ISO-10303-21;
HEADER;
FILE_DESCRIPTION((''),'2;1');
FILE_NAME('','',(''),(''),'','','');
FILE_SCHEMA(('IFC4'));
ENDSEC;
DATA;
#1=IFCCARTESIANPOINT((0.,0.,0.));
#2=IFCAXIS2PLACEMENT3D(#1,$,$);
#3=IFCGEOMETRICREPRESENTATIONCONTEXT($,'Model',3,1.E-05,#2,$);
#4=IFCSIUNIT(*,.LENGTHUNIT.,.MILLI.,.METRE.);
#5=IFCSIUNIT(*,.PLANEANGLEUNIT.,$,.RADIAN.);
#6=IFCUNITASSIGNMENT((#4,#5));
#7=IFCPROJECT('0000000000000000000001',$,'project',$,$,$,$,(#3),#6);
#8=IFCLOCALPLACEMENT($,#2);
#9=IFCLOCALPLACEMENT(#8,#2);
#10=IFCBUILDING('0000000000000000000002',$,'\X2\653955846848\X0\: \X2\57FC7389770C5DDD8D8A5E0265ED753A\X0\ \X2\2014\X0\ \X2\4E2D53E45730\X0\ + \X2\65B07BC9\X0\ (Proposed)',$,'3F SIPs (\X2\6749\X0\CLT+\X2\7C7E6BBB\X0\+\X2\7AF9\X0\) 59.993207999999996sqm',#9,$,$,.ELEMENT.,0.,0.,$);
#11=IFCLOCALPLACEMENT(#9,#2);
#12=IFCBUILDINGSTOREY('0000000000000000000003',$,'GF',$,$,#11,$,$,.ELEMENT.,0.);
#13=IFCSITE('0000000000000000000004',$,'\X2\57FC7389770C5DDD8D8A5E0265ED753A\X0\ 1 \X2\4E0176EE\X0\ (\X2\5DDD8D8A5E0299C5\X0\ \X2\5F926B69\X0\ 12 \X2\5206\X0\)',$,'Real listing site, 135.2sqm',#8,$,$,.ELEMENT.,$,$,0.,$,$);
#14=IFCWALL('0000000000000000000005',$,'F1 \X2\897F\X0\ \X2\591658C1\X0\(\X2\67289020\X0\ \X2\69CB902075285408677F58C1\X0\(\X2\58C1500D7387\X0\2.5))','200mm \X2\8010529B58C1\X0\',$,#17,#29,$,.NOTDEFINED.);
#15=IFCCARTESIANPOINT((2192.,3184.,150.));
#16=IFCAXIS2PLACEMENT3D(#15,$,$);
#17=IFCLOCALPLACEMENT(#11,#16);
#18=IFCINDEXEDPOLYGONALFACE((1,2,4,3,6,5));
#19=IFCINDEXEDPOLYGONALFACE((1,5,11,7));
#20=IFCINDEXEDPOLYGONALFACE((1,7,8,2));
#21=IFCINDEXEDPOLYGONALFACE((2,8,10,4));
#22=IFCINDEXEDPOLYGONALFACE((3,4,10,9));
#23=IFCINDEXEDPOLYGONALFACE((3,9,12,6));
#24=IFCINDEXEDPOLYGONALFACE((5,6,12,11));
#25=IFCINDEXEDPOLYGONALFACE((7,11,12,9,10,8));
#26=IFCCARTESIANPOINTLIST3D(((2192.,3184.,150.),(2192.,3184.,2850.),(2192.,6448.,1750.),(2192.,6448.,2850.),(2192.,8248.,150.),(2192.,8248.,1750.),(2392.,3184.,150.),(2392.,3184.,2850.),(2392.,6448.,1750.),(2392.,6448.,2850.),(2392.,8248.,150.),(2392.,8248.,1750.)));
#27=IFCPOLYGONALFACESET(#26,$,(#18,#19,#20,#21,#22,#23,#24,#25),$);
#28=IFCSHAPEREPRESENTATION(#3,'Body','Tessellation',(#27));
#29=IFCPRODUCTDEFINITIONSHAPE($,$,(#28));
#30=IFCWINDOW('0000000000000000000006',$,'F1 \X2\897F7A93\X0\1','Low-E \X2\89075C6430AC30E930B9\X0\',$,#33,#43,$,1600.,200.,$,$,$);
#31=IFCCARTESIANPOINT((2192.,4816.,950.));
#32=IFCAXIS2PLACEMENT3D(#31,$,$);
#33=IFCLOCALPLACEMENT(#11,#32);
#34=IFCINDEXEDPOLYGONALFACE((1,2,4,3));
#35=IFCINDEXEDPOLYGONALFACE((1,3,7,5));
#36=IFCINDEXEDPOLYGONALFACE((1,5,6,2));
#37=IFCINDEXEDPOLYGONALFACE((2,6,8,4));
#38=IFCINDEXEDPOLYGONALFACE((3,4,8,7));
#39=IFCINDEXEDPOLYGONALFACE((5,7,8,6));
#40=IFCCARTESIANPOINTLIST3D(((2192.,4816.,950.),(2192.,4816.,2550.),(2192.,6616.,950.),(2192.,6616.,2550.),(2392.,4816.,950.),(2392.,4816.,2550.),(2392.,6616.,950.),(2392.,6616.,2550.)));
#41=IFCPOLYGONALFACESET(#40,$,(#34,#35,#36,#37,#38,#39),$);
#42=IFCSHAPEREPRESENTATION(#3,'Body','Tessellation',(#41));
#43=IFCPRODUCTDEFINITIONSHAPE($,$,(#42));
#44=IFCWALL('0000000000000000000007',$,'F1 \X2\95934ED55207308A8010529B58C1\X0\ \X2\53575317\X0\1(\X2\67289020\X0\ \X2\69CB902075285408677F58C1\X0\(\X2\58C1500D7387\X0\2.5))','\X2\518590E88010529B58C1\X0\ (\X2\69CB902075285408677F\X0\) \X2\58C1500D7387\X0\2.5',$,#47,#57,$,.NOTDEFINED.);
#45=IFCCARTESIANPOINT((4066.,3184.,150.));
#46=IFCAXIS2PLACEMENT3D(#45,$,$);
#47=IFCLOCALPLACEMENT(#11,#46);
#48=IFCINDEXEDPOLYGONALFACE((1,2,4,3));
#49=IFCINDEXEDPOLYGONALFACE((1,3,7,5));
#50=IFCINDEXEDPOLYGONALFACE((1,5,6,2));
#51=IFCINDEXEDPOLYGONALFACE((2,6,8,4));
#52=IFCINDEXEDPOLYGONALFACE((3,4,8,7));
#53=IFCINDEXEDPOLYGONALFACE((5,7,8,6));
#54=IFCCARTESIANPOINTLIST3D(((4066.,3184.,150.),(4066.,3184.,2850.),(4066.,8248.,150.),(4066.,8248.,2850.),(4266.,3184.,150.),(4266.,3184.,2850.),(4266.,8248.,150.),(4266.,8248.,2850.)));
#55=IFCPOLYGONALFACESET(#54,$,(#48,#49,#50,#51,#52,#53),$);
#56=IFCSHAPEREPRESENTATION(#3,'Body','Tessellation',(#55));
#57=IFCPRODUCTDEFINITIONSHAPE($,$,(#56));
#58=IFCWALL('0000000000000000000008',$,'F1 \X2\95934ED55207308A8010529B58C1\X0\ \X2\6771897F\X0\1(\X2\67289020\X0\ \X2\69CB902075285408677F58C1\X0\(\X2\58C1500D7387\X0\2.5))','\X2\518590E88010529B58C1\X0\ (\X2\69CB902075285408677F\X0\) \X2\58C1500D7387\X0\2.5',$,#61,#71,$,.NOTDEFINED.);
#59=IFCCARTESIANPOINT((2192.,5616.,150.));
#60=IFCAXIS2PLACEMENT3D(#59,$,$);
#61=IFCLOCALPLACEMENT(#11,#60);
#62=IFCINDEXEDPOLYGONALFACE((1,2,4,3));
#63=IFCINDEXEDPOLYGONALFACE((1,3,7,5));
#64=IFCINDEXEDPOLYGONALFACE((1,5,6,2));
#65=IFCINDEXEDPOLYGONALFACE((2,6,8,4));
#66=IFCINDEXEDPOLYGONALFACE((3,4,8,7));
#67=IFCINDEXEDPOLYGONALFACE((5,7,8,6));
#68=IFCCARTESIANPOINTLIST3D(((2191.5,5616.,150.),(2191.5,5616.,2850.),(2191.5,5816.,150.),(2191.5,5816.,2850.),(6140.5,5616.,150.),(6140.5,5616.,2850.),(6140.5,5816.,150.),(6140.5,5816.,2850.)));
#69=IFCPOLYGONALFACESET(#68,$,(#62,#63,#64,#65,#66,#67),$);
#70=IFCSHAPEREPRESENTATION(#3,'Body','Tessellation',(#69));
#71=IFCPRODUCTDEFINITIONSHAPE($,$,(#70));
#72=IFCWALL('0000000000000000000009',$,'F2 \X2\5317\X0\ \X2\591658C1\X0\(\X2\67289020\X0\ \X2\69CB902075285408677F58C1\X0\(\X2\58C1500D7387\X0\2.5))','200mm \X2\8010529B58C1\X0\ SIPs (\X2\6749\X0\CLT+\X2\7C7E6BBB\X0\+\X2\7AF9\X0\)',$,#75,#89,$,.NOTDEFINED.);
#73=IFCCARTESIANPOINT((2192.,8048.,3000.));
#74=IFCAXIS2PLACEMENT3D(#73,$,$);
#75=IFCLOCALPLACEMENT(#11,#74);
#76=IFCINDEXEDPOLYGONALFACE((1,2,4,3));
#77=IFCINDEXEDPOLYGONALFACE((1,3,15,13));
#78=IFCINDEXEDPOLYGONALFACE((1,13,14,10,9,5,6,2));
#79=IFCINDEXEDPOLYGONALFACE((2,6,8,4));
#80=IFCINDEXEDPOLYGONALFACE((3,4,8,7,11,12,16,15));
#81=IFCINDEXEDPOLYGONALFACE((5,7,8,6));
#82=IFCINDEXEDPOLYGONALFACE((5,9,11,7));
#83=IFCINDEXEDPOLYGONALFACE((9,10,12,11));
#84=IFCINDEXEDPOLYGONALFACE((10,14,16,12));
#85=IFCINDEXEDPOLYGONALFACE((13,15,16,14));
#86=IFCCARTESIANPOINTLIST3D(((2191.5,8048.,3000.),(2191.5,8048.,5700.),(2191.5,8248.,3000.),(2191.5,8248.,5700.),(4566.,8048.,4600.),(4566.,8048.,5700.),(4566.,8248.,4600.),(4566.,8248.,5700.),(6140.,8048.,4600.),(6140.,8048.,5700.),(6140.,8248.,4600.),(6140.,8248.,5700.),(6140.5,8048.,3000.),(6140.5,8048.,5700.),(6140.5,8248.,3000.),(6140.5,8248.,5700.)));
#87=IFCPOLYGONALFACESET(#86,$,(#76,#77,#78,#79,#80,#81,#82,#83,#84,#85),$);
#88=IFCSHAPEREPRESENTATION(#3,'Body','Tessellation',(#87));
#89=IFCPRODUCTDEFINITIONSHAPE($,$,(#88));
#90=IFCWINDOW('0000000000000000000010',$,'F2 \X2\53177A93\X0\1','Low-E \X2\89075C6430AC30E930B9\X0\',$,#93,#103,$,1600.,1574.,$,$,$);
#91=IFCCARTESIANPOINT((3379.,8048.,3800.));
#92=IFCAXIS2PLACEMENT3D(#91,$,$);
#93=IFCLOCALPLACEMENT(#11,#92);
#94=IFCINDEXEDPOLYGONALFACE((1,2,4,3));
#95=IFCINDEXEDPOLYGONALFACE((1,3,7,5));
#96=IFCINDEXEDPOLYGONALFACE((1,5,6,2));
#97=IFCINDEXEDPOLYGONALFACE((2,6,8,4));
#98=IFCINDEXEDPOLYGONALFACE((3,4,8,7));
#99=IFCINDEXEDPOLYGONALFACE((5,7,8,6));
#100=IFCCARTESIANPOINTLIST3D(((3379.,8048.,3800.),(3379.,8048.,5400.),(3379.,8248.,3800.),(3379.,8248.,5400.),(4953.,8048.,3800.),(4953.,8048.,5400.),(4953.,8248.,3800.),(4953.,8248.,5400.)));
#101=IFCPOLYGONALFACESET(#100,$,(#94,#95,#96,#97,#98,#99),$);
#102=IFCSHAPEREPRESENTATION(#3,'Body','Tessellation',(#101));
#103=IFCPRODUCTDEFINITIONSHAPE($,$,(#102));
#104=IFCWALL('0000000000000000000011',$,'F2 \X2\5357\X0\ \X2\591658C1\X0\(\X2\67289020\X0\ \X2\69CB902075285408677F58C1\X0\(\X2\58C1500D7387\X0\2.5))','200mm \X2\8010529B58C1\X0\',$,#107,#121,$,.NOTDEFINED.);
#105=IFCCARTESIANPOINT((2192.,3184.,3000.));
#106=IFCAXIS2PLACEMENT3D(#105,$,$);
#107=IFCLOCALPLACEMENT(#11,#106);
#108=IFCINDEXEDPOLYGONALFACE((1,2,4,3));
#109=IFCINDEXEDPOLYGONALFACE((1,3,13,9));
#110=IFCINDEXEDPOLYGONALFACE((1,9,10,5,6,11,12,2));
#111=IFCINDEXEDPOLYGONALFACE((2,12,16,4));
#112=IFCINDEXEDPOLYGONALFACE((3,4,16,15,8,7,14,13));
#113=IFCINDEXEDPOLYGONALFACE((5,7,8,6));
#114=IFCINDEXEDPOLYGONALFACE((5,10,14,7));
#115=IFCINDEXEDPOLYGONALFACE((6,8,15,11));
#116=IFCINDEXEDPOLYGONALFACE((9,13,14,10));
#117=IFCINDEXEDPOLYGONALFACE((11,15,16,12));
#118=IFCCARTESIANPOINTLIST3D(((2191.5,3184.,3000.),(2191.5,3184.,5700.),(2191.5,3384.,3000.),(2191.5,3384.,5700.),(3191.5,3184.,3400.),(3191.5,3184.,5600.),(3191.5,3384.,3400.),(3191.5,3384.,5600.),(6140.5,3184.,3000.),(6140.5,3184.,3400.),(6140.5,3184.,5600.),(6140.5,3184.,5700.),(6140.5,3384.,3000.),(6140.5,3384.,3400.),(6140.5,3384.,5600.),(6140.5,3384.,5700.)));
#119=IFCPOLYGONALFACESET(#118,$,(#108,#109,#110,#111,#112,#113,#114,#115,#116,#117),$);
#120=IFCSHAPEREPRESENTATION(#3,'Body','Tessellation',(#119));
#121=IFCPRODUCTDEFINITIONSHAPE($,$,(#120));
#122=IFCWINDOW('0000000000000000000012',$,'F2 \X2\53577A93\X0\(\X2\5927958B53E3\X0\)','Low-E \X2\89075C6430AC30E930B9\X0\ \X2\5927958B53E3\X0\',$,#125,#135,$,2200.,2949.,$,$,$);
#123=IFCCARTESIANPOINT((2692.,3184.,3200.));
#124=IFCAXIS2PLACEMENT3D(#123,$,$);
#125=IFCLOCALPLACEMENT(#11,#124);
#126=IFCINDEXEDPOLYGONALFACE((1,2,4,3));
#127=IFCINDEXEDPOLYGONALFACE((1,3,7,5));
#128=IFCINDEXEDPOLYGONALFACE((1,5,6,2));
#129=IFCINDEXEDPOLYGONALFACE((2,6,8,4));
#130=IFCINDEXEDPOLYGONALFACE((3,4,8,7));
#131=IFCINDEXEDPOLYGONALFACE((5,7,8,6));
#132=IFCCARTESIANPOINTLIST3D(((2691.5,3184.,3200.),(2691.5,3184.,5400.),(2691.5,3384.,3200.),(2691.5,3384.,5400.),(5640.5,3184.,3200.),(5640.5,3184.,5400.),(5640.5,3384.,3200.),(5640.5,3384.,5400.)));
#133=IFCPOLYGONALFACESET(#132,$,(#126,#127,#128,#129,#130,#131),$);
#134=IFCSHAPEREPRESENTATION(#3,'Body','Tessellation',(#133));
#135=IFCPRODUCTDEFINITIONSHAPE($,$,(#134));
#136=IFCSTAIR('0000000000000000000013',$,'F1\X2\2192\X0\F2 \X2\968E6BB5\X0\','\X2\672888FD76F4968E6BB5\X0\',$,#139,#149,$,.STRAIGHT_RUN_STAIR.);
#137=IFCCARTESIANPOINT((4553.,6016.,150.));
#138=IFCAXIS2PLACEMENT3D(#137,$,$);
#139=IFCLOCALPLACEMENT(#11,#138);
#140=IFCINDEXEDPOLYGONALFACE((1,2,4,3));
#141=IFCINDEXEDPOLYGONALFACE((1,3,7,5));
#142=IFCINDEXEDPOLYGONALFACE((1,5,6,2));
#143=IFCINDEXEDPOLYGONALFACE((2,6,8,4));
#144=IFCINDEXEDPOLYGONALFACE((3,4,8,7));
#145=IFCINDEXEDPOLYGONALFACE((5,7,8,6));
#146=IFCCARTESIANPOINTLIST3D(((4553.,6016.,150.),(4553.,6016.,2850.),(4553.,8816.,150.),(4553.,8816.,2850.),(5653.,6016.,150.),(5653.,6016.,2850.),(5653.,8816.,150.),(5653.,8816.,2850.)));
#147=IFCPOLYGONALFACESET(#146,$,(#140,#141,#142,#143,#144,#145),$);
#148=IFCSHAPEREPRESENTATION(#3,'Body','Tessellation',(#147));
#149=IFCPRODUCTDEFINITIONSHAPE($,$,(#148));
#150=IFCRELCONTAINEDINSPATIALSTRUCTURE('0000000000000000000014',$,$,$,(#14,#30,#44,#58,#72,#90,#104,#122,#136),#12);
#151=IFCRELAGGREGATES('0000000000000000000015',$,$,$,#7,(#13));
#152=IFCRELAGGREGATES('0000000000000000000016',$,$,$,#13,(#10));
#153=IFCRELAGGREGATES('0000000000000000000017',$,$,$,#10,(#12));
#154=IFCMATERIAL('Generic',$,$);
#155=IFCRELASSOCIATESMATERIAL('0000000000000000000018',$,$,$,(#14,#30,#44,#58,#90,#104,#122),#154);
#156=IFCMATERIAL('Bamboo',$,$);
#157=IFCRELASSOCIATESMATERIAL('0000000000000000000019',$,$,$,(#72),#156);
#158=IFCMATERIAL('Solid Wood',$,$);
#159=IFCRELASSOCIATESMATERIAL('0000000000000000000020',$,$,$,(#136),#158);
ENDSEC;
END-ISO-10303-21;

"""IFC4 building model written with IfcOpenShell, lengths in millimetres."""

from ifc_helpers import new_model, si_unit, frame, frame_2d, origin, place, context, project, spatial, rectangle, extrude, material, element, fill, save


model = new_model("IFC4")

# Units and contexts
model_context = context("Model", 3, precision=1e-05, world=origin())
ifc_project = project(units=[si_unit("LENGTHUNIT", "METRE", prefix="MILLI"), si_unit("PLANEANGLEUNIT", "RADIAN")], contexts=[model_context])

# Site, building, storey
site_placement = place(None, origin())
site = spatial("IfcSite", under=ifc_project, at=site_placement, Name="埼玉県川越市旭町 1 丁目 (川越市駅 徒歩 12 分)", ObjectType="Real listing site, 135.2sqm", CompositionType="ELEMENT", RefElevation=0.0)
building_placement = place(site_placement, origin())
building = spatial("IfcBuilding", under=site, at=building_placement, Name="改善案: 埼玉県川越市旭町 — 中古地 + 新築 (Proposed)", ObjectType="3F SIPs (杉CLT+籾殻+竹) 59.993207999999996sqm", CompositionType="ELEMENT", ElevationOfRefHeight=0.0, ElevationOfTerrain=0.0)
storey_placement = place(building_placement, origin())
storey = spatial("IfcBuildingStorey", under=building, at=storey_placement, Name="GF", CompositionType="ELEMENT", Elevation=0.0)

# Shared definitions
ifc_material_1 = material(Name="Generic")

# Shared definitions
ifc_material_2 = material(Name="Bamboo")

# Shared definitions
ifc_material_3 = material(Name="Solid Wood")

# Wall, opening, window
wall_1_placement = place(storey_placement, frame((2192.0, 3184.0, 150.0)))
wall_1 = element("IfcWall", 1, at=wall_1_placement, inside=storey, material=ifc_material_1, Name="F1 西 外壁(木造 構造用合板壁(壁倍率2.5))", Description="200mm 耐力壁", PredefinedType="NOTDEFINED", context=model_context, shape_type="SweptSolid", body=[
    extrude(rectangle(XDim=200.0, YDim=5064.0, at=frame_2d((100.0, 2532.0))), frame((2192.0, 3184.0, 150.0)), (0.0, 0.0, 1.0), 2700.0),
])
opening_1_placement = place(storey_placement, frame((2192.0, 4816.0, 950.0)))
opening_1 = element("IfcOpeningElement", 2, at=opening_1_placement, cuts=wall_1, PredefinedType="NOTDEFINED", context=model_context, shape_type="SweptSolid", body=[
    extrude(rectangle(XDim=200.0, YDim=1800.0, at=frame_2d((100.0, 900.0))), frame((2192.0, 4816.0, 950.0)), (0.0, 0.0, 1.0), 1600.0),
])
window_1_placement = place(storey_placement, frame((2192.0, 4816.0, 950.0)))
window_1 = element("IfcWindow", 3, at=window_1_placement, inside=storey, material=ifc_material_1, Name="F1 西窓1", Description="Low-E 複層ガラス", OverallHeight=1600.0, OverallWidth=200.0, context=model_context, shape_type="SweptSolid", body=[
    extrude(rectangle(XDim=200.0, YDim=1800.0, at=frame_2d((100.0, 900.0))), frame((2192.0, 4816.0, 950.0)), (0.0, 0.0, 1.0), 1600.0),
])
fill(opening_1, window_1)

# Walls
wall_2_placement = place(storey_placement, frame((4066.0, 3184.0, 150.0)))
element("IfcWall", 4, at=wall_2_placement, inside=storey, material=ifc_material_1, Name="F1 間仕切り耐力壁 南北1(木造 構造用合板壁(壁倍率2.5))", Description="内部耐力壁 (構造用合板) 壁倍率2.5", PredefinedType="NOTDEFINED", context=model_context, shape_type="SweptSolid", body=[
    extrude(rectangle(XDim=200.0, YDim=5064.0, at=frame_2d((100.0, 2532.0))), frame((4066.0, 3184.0, 150.0)), (0.0, 0.0, 1.0), 2700.0),
])
wall_3_placement = place(storey_placement, frame((2192.0, 5616.0, 150.0)))
element("IfcWall", 5, at=wall_3_placement, inside=storey, material=ifc_material_1, Name="F1 間仕切り耐力壁 東西1(木造 構造用合板壁(壁倍率2.5))", Description="内部耐力壁 (構造用合板) 壁倍率2.5", PredefinedType="NOTDEFINED", context=model_context, shape_type="SweptSolid", body=[
    extrude(rectangle(XDim=3949.0, YDim=200.0, at=frame_2d((1974.0, 100.0))), frame((2192.0, 5616.0, 150.0)), (0.0, 0.0, 1.0), 2700.0),
])

# Walls, openings, windows
wall_4_placement = place(storey_placement, frame((2192.0, 8048.0, 3000.0)))
wall_4 = element("IfcWall", 6, at=wall_4_placement, inside=storey, material=ifc_material_2, Name="F2 北 外壁(木造 構造用合板壁(壁倍率2.5))", Description="200mm 耐力壁 SIPs (杉CLT+籾殻+竹)", PredefinedType="NOTDEFINED", context=model_context, shape_type="SweptSolid", body=[
    extrude(rectangle(XDim=3949.0, YDim=200.0, at=frame_2d((1974.0, 100.0))), frame((2192.0, 8048.0, 3000.0)), (0.0, 0.0, 1.0), 2700.0),
])
opening_2_placement = place(storey_placement, frame((3379.0, 8048.0, 3800.0)))
opening_2 = element("IfcOpeningElement", 7, at=opening_2_placement, cuts=wall_4, PredefinedType="NOTDEFINED", context=model_context, shape_type="SweptSolid", body=[
    extrude(rectangle(XDim=1574.0, YDim=200.0, at=frame_2d((787.0, 100.0))), frame((3379.0, 8048.0, 3800.0)), (0.0, 0.0, 1.0), 1600.0),
])
window_2_placement = place(storey_placement, frame((3379.0, 8048.0, 3800.0)))
window_2 = element("IfcWindow", 8, at=window_2_placement, inside=storey, material=ifc_material_1, Name="F2 北窓1", Description="Low-E 複層ガラス", OverallHeight=1600.0, OverallWidth=1574.0, context=model_context, shape_type="SweptSolid", body=[
    extrude(rectangle(XDim=1574.0, YDim=200.0, at=frame_2d((787.0, 100.0))), frame((3379.0, 8048.0, 3800.0)), (0.0, 0.0, 1.0), 1600.0),
])
fill(opening_2, window_2)
wall_5_placement = place(storey_placement, frame((2192.0, 3184.0, 3000.0)))
wall_5 = element("IfcWall", 9, at=wall_5_placement, inside=storey, material=ifc_material_1, Name="F2 南 外壁(木造 構造用合板壁(壁倍率2.5))", Description="200mm 耐力壁", PredefinedType="NOTDEFINED", context=model_context, shape_type="SweptSolid", body=[
    extrude(rectangle(XDim=3949.0, YDim=200.0, at=frame_2d((1974.0, 100.0))), frame((2192.0, 3184.0, 3000.0)), (0.0, 0.0, 1.0), 2700.0),
])
opening_3_placement = place(storey_placement, frame((2692.0, 3184.0, 3200.0)))
opening_3 = element("IfcOpeningElement", 10, at=opening_3_placement, cuts=wall_5, PredefinedType="NOTDEFINED", context=model_context, shape_type="SweptSolid", body=[
    extrude(rectangle(XDim=2949.0, YDim=200.0, at=frame_2d((1474.0, 100.0))), frame((2692.0, 3184.0, 3200.0)), (0.0, 0.0, 1.0), 2200.0),
])
window_3_placement = place(storey_placement, frame((2692.0, 3184.0, 3200.0)))
window_3 = element("IfcWindow", 11, at=window_3_placement, inside=storey, material=ifc_material_1, Name="F2 南窓(大開口)", Description="Low-E 複層ガラス 大開口", OverallHeight=2200.0, OverallWidth=2949.0, context=model_context, shape_type="SweptSolid", body=[
    extrude(rectangle(XDim=2949.0, YDim=200.0, at=frame_2d((1474.0, 100.0))), frame((2692.0, 3184.0, 3200.0)), (0.0, 0.0, 1.0), 2200.0),
])
fill(opening_3, window_3)

# Stair
stair_placement = place(storey_placement, frame((4553.0, 6016.0, 150.0)))
element("IfcStair", 12, at=stair_placement, inside=storey, material=ifc_material_3, Name="F1→F2 階段", Description="木製直階段", PredefinedType="STRAIGHT_RUN_STAIR", context=model_context, shape_type="SweptSolid", body=[
    extrude(rectangle(XDim=1100.0, YDim=2800.0, at=frame_2d((550.0, 1400.0))), frame((4553.0, 6016.0, 150.0)), (0.0, 0.0, 1.0), 2700.0),
])

save(model, "model.ifc")
